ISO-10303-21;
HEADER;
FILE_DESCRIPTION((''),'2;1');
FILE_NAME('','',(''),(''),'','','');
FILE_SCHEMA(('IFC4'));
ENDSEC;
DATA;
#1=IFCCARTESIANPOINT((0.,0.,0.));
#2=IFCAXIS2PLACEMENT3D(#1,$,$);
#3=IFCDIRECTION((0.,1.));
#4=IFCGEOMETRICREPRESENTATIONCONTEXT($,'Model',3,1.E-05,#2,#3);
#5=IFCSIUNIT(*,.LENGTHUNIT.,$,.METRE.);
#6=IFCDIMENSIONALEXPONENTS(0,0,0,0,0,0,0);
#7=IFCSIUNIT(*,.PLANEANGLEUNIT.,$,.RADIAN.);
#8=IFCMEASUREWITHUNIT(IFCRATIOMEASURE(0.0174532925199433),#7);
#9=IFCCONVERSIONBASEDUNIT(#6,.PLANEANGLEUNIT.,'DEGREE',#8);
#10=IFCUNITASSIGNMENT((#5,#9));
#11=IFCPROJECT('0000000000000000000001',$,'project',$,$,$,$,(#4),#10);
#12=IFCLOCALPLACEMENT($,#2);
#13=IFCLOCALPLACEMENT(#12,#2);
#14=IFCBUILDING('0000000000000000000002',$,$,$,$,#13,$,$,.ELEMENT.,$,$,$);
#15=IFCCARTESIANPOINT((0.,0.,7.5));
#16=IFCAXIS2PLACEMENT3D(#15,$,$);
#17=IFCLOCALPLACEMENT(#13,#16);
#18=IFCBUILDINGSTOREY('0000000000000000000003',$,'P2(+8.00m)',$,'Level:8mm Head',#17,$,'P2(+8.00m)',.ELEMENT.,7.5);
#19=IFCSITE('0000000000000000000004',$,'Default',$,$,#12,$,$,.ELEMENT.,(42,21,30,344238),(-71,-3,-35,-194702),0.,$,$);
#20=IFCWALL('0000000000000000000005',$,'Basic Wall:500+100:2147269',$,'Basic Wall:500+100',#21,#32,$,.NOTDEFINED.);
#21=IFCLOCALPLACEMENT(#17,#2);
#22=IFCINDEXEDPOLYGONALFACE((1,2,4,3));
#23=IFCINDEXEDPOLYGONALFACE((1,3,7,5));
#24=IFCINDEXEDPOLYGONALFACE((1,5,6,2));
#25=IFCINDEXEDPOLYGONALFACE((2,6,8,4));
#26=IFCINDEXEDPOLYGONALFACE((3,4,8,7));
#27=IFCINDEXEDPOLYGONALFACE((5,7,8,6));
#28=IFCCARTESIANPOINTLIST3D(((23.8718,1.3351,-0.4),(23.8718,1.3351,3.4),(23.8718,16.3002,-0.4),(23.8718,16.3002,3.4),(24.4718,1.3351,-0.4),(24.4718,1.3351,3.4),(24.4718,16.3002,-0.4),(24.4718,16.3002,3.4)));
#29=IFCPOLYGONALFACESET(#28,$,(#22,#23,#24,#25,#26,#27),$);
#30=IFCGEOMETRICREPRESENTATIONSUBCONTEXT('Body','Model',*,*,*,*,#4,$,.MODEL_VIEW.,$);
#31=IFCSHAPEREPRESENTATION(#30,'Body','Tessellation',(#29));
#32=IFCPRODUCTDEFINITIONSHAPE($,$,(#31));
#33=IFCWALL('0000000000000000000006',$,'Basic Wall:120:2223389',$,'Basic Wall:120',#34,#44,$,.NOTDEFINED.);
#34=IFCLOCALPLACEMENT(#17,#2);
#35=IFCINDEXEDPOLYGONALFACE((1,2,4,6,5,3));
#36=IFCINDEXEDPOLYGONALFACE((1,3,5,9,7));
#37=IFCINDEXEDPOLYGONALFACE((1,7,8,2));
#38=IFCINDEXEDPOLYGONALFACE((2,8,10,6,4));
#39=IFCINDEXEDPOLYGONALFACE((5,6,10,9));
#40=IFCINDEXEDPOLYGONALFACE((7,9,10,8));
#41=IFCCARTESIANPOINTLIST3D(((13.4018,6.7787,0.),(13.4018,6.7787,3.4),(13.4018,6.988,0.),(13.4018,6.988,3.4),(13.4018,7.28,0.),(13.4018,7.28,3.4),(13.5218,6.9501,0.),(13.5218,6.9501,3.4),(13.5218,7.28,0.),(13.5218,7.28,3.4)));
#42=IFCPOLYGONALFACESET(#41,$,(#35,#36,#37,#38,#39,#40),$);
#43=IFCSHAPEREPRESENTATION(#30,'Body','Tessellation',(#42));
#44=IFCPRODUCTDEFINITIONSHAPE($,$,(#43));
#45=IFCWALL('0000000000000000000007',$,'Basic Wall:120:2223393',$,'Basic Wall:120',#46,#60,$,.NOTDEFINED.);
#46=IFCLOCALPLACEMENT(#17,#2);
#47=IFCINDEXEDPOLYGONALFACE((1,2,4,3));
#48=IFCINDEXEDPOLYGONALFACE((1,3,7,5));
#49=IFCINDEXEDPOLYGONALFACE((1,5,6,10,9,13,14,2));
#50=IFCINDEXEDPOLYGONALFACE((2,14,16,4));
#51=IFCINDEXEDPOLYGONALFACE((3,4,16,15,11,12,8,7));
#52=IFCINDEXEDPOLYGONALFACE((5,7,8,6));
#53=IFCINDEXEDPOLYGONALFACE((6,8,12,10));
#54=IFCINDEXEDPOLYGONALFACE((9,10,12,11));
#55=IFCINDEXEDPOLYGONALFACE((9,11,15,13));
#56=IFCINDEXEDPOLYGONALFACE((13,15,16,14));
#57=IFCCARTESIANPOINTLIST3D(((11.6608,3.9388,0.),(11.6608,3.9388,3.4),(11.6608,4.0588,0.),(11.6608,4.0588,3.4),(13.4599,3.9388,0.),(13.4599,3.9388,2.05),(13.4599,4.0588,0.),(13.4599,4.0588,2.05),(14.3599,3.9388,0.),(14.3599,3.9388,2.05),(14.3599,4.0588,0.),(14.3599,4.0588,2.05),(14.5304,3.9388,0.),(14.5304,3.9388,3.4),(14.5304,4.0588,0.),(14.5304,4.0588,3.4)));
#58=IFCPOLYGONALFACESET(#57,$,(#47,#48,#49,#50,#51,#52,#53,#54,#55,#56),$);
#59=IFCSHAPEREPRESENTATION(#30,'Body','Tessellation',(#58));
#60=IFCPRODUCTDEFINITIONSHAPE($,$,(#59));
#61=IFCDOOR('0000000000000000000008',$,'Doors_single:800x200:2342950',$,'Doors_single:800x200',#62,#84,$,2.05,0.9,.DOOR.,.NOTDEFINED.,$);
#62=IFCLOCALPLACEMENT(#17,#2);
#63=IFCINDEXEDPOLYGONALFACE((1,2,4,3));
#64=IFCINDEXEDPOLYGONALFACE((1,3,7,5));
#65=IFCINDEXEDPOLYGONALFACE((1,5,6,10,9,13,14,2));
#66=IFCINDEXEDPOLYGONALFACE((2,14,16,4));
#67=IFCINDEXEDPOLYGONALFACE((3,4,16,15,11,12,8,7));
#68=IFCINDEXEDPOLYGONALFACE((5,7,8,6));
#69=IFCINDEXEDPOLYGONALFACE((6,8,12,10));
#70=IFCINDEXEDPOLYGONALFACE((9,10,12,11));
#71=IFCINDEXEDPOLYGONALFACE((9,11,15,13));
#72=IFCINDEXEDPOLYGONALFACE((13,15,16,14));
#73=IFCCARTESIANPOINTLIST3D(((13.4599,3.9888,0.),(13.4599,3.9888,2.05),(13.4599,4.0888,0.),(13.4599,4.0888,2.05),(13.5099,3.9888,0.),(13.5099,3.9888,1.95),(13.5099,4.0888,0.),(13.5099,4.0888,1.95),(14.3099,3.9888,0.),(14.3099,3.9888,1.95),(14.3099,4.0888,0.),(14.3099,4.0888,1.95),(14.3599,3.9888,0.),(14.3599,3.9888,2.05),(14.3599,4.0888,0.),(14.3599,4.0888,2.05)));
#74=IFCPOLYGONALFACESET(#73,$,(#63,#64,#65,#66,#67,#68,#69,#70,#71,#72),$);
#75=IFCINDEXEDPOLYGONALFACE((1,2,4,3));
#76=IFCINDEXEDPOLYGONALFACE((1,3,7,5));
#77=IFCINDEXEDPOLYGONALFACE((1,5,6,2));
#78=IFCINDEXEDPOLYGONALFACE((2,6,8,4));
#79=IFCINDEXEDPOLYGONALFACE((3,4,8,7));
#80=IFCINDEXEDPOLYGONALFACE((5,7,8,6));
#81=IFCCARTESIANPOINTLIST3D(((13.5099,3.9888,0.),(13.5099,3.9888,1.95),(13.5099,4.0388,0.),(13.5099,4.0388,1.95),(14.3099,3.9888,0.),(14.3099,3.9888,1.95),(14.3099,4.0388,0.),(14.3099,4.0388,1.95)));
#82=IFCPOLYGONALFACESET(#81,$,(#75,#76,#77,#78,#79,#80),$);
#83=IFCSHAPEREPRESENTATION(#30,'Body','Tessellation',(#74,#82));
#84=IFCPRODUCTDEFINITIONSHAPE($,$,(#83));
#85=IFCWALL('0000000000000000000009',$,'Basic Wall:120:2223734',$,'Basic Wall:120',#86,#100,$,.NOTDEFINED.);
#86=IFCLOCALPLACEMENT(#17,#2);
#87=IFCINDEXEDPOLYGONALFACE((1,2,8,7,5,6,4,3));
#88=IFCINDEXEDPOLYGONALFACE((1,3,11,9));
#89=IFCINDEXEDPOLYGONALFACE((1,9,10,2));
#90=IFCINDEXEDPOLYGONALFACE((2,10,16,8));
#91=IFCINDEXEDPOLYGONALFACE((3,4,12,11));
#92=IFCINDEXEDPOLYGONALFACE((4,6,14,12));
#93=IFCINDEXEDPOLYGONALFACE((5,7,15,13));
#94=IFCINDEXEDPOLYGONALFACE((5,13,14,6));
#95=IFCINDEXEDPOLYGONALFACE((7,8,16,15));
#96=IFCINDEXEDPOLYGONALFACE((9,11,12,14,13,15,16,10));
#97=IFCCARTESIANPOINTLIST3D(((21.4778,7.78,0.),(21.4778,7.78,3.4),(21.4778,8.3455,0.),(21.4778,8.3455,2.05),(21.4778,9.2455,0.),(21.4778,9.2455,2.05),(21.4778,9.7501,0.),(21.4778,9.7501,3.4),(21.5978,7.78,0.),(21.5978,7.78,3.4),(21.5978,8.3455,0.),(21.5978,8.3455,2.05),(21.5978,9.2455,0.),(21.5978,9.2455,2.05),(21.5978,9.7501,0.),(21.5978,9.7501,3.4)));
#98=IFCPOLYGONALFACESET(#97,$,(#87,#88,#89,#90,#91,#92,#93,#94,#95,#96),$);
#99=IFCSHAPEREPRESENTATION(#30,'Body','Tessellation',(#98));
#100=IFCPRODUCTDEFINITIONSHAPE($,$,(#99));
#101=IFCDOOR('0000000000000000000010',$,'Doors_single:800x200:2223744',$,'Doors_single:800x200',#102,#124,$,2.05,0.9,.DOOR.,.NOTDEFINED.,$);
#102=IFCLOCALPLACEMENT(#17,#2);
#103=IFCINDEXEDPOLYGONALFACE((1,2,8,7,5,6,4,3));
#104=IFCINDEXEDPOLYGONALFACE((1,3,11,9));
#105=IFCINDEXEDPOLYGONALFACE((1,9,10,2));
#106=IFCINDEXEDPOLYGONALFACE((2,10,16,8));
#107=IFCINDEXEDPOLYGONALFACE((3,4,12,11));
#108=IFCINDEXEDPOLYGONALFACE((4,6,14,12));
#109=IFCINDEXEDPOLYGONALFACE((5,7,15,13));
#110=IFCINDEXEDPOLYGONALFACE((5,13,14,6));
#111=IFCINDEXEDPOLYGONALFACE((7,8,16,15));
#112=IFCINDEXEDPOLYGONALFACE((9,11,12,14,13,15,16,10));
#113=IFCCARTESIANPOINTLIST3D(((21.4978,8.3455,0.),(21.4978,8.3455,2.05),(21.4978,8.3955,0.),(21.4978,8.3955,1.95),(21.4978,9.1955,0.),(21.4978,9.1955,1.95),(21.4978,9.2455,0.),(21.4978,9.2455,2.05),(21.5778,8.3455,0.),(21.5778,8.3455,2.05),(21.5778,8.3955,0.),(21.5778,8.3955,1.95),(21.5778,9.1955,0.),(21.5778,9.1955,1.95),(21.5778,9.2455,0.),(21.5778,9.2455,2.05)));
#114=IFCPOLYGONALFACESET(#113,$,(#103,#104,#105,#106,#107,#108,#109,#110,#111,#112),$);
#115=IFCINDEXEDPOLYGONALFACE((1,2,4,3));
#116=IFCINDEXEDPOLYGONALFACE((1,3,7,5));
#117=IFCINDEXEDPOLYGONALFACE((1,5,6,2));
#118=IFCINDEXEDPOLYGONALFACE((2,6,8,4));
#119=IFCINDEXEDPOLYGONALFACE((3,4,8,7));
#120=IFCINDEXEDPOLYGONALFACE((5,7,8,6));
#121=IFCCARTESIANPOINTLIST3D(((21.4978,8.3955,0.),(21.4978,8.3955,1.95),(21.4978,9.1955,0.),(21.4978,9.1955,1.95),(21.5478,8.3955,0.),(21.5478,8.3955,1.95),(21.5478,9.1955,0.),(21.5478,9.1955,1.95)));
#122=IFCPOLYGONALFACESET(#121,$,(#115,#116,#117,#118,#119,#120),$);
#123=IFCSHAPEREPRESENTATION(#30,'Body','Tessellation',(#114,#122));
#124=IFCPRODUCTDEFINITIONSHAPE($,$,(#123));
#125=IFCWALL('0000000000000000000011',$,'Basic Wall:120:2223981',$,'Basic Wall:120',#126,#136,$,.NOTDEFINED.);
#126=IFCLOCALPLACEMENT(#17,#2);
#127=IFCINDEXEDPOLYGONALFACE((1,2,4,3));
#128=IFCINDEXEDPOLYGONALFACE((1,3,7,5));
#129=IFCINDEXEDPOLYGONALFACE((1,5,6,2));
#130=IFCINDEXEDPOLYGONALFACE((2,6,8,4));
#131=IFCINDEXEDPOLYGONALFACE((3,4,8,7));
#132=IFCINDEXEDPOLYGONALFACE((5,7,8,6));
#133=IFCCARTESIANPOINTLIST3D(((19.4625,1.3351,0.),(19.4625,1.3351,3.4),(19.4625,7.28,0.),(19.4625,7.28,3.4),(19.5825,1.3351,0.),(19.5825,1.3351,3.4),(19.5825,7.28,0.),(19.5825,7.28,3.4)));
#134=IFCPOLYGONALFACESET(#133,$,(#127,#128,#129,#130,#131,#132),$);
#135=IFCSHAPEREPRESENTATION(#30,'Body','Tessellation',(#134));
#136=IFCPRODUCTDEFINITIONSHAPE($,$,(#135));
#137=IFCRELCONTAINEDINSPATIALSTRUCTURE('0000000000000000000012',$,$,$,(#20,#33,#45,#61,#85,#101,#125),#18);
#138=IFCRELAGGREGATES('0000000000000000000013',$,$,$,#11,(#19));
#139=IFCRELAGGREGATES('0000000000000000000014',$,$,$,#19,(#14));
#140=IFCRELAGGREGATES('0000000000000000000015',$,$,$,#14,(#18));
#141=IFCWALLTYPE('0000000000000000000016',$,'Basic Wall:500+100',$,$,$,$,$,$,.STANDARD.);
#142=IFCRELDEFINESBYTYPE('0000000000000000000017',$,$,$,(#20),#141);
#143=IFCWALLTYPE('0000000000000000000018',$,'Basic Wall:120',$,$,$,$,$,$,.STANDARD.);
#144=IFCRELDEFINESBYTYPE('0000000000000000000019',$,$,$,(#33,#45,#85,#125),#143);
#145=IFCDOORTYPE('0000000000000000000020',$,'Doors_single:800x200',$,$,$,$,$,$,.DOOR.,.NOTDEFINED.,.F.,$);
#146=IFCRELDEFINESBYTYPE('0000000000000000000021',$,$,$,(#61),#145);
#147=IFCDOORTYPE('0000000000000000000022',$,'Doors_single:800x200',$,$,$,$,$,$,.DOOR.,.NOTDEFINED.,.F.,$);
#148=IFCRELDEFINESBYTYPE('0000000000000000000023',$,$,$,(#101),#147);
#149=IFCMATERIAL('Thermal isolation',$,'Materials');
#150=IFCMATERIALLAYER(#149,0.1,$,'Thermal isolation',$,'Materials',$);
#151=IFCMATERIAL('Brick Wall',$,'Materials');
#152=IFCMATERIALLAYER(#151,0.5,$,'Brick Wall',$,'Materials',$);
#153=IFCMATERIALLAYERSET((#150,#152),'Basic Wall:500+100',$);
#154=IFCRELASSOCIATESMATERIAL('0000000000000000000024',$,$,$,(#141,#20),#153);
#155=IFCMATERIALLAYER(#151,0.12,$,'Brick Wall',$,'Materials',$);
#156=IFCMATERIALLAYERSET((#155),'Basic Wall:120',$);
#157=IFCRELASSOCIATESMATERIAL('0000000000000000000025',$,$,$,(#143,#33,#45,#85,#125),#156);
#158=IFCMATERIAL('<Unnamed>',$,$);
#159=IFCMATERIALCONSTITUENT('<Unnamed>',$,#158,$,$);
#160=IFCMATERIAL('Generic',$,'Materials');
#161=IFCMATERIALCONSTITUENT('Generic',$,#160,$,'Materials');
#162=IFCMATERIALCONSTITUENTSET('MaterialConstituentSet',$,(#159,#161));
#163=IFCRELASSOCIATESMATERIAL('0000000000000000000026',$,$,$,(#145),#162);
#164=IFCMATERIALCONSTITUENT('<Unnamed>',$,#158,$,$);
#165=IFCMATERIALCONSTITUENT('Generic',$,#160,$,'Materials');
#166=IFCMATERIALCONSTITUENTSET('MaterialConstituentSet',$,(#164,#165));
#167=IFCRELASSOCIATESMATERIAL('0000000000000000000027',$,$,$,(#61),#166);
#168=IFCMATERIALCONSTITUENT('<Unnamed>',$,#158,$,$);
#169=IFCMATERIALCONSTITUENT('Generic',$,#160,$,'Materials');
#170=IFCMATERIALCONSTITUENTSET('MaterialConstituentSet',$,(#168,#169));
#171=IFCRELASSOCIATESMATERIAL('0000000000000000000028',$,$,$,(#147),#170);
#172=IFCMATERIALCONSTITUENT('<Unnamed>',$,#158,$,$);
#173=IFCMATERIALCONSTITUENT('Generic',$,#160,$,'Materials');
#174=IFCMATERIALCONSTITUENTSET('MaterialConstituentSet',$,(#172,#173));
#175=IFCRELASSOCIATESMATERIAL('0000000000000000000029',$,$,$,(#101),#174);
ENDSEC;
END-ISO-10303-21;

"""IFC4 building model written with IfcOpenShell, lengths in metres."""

from ifc_helpers import new_model, entity, si_unit, converted_unit, direction, frame, frame_2d, origin, origin_2d_with_axis, place, context, subcontext, project, spatial, polyline, rectangle, outline, extrude, source, transform, mapped, material, layer, layer_set, layer_usage, constituent, constituent_set, type_object, type_shapes, element, fill, save


model = new_model("IFC4")

# Units and contexts
model_context = context("Model", 3, precision=1e-05, world=origin(), true_north=direction((0.0, 1.0)))
body_context = subcontext(model_context, "Body", "Model", "MODEL_VIEW")
ifc_project = project(units=[si_unit("LENGTHUNIT", "METRE"), converted_unit("PLANEANGLEUNIT", "DEGREE", entity("IfcRatioMeasure", 0.0174532925199433), si_unit("PLANEANGLEUNIT", "RADIAN"), dimensions=[0, 0, 0, 0, 0, 0, 0])], contexts=[model_context])

# Site, building, storey
site_placement = place(None, origin())
site = spatial("IfcSite", under=ifc_project, at=site_placement, Name="Default", CompositionType="ELEMENT", RefLatitude=(42, 21, 30, 344238), RefLongitude=(-71, -3, -35, -194702), RefElevation=0.0)
building_placement = place(site_placement, origin())
building = spatial("IfcBuilding", under=site, at=building_placement, CompositionType="ELEMENT")
storey_placement = place(building_placement, frame((0.0, 0.0, 7.5)))
storey = spatial("IfcBuildingStorey", under=building, at=storey_placement, Name="P2(+8.00m)", ObjectType="Level:8mm Head", LongName="P2(+8.00m)", CompositionType="ELEMENT", Elevation=7.5)

# Shared definitions
ifc_material_1 = material(Name="Thermal isolation", Category="Materials")
ifc_layer_1 = layer(ifc_material_1, 0.1, Name="Thermal isolation", Category="Materials")
ifc_material_2 = material(Name="Brick Wall", Category="Materials")
ifc_layer_2 = layer(ifc_material_2, 0.5, Name="Brick Wall", Category="Materials")
ifc_layer_set_1 = layer_set([ifc_layer_1, ifc_layer_2], Name="Basic Wall:500+100")
wall_type_1 = type_object("IfcWallType", Name="Basic Wall:500+100", PredefinedType="STANDARD", material=ifc_layer_set_1)
ifc_material_3 = material(Name="<Unnamed>")
ifc_material_4 = material(Name="Generic", Category="Materials")

# Walls
ifc_layer_usage_1 = layer_usage(ifc_layer_set_1, "AXIS2", "POSITIVE", -0.3)
wall_1_placement = place(storey_placement, frame((24.1718, 1.3351, -0.4), z_axis=(0.0, 0.0, 1.0), x_axis=(0.0, 1.0, 0.0)))
element("IfcWall", 1, at=wall_1_placement, inside=storey, type_object=wall_type_1, material=ifc_layer_usage_1, Name="Basic Wall:500+100:2147269", ObjectType="Basic Wall:500+100", PredefinedType="NOTDEFINED", context=body_context, shape_type="SweptSolid", body=[
    extrude(rectangle(XDim=14.9651, YDim=0.6, at=frame_2d((7.4826, 0.0), x_axis=(-1.0, 0.0))), origin(), (0.0, 0.0, 1.0), 3.8),
])
ifc_layer_3 = layer(ifc_material_2, 0.12, Name="Brick Wall", Category="Materials")
ifc_layer_set_2 = layer_set([ifc_layer_3], Name="Basic Wall:120")
ifc_layer_usage_2 = layer_usage(ifc_layer_set_2, "AXIS2", "POSITIVE", -0.06)
wall_type_2 = type_object("IfcWallType", Name="Basic Wall:120", PredefinedType="STANDARD", material=ifc_layer_set_2)
wall_2_placement = place(storey_placement, frame((13.4618, 7.28, 0.0), z_axis=(0.0, 0.0, 1.0), x_axis=(0.0, -1.0, 0.0)))
element("IfcWall", 2, at=wall_2_placement, inside=storey, type_object=wall_type_2, material=ifc_layer_usage_2, Name="Basic Wall:120:2223389", ObjectType="Basic Wall:120", PredefinedType="NOTDEFINED", context=body_context, shape_type="SweptSolid", body=[
    extrude(outline(polyline([(0.5012, -0.06), (0.3298, 0.06), (0.0, 0.06), (0.0, -0.06), (0.292, -0.06), (0.5012, -0.06)])), origin(), (0.0, 0.0, 1.0), 3.4),
])

# Walls, openings, doors
ifc_layer_usage_3 = layer_usage(ifc_layer_set_2, "AXIS2", "POSITIVE", -0.06)
wall_3_placement = place(storey_placement, frame((14.5304, 3.9988, 0.0), z_axis=(0.0, 0.0, 1.0), x_axis=(-1.0, 0.0, 0.0)))
wall_3 = element("IfcWall", 3, at=wall_3_placement, inside=storey, type_object=wall_type_2, material=ifc_layer_usage_3, Name="Basic Wall:120:2223393", ObjectType="Basic Wall:120", PredefinedType="NOTDEFINED", context=body_context, shape_type="SweptSolid", body=[
    extrude(rectangle(XDim=2.8696, YDim=0.12, at=frame_2d((1.4348, 0.0), x_axis=(-1.0, 0.0))), origin(), (0.0, 0.0, 1.0), 3.4),
])
opening_1_placement = place(wall_3_placement, frame((0.1705, -0.06, 0.0)))
opening_1 = element("IfcOpeningElement", 4, at=opening_1_placement, cuts=wall_3, PredefinedType="OPENING", context=body_context, shape_type="SweptSolid", body=[
    extrude(rectangle(XDim=2.05, YDim=0.9, at=frame_2d((1.025, 0.45), x_axis=(1.0, 0.0))), frame((0.0, 0.0, 0.0), z_axis=(0.0, 1.0, 0.0), x_axis=(0.0, 0.0, 1.0)), (0.0, 0.0, 1.0), 0.12),
])
ifc_constituent_1 = constituent(ifc_material_3, Name="<Unnamed>")
ifc_constituent_2 = constituent(ifc_material_4, Name="Generic", Category="Materials")
ifc_constituent_set_1 = constituent_set(constituents=[ifc_constituent_1, ifc_constituent_2], Name="MaterialConstituentSet")
ifc_constituent_3 = constituent(ifc_material_3, Name="<Unnamed>")
ifc_constituent_4 = constituent(ifc_material_4, Name="Generic", Category="Materials")
ifc_constituent_set_2 = constituent_set(constituents=[ifc_constituent_3, ifc_constituent_4], Name="MaterialConstituentSet")
door_type_1 = type_object("IfcDoorType", Name="Doors_single:800x200", OperationType="NOTDEFINED", ParameterTakesPrecedence=False, PredefinedType="DOOR", material=ifc_constituent_set_2)
shared_shape_1 = source(origin(), body_context, "Body", "SweptSolid", [
    extrude(outline(polyline([(-0.45, -1.0), (-0.4, -1.0), (-0.4, 0.95), (0.4, 0.95), (0.4, -1.0), (0.45, -1.0), (0.45, 1.05), (-0.45, 1.05), (-0.45, -1.0)])), frame((0.45, -0.03, 1.0), z_axis=(0.0, 1.0, 0.0), x_axis=(-1.0, 0.0, 0.0)), (0.0, 0.0, 1.0), 0.1),
    extrude(rectangle(XDim=0.8, YDim=0.05, at=origin_2d_with_axis()), frame((0.45, 0.045, 0.0), z_axis=(0.0, 0.0, 1.0), x_axis=(-1.0, 0.0, 0.0)), (0.0, 0.0, 1.0), 1.95),
])
type_shapes(door_type_1, [shared_shape_1])
door_1_placement = place(opening_1_placement, origin())
door_1 = element("IfcDoor", 5, at=door_1_placement, inside=storey, type_object=door_type_1, material=ifc_constituent_set_1, Name="Doors_single:800x200:2342950", ObjectType="Doors_single:800x200", OperationType="NOTDEFINED", OverallHeight=2.05, OverallWidth=0.9, PredefinedType="DOOR", context=body_context, shape_type="MappedRepresentation", body=[
    mapped(shared_shape_1, transform((0.0, 0.0, 0.0), scale=1.0)),
])
fill(opening_1, door_1)
ifc_layer_usage_4 = layer_usage(ifc_layer_set_2, "AXIS2", "NEGATIVE", 0.06)
wall_4_placement = place(storey_placement, frame((21.5378, 9.7501, 0.0), z_axis=(0.0, 0.0, 1.0), x_axis=(0.0, -1.0, 0.0)))
wall_4 = element("IfcWall", 6, at=wall_4_placement, inside=storey, type_object=wall_type_2, material=ifc_layer_usage_4, Name="Basic Wall:120:2223734", ObjectType="Basic Wall:120", PredefinedType="NOTDEFINED", context=body_context, shape_type="SweptSolid", body=[
    extrude(rectangle(XDim=1.9701, YDim=0.12, at=frame_2d((0.985, 0.0), x_axis=(-1.0, 0.0))), origin(), (0.0, 0.0, 1.0), 3.4),
])
opening_2_placement = place(wall_4_placement, frame((1.4045, 0.06, 0.0)))
opening_2 = element("IfcOpeningElement", 7, at=opening_2_placement, cuts=wall_4, PredefinedType="OPENING", context=body_context, shape_type="SweptSolid", body=[
    extrude(rectangle(XDim=2.05, YDim=0.9, at=frame_2d((1.025, 0.45), x_axis=(1.0, 0.0))), frame((0.0, 0.0, 0.0), z_axis=(0.0, -1.0, 0.0), x_axis=(0.0, 0.0, 1.0)), (0.0, 0.0, 1.0), 0.12),
])
ifc_constituent_5 = constituent(ifc_material_3, Name="<Unnamed>")
ifc_constituent_6 = constituent(ifc_material_4, Name="Generic", Category="Materials")
ifc_constituent_set_3 = constituent_set(constituents=[ifc_constituent_5, ifc_constituent_6], Name="MaterialConstituentSet")
ifc_constituent_7 = constituent(ifc_material_3, Name="<Unnamed>")
ifc_constituent_8 = constituent(ifc_material_4, Name="Generic", Category="Materials")
ifc_constituent_set_4 = constituent_set(constituents=[ifc_constituent_7, ifc_constituent_8], Name="MaterialConstituentSet")
door_type_2 = type_object("IfcDoorType", Name="Doors_single:800x200", OperationType="NOTDEFINED", ParameterTakesPrecedence=False, PredefinedType="DOOR", material=ifc_constituent_set_4)
shared_shape_2 = source(origin(), body_context, "Body", "SweptSolid", [
    extrude(outline(polyline([(-0.45, -1.0), (-0.4, -1.0), (-0.4, 0.95), (0.4, 0.95), (0.4, -1.0), (0.45, -1.0), (0.45, 1.05), (-0.45, 1.05), (-0.45, -1.0)])), frame((0.45, 0.02, 1.0), z_axis=(0.0, 1.0, 0.0), x_axis=(-1.0, 0.0, 0.0)), (0.0, 0.0, 1.0), 0.08),
    extrude(rectangle(XDim=0.8, YDim=0.05, at=origin_2d_with_axis()), frame((0.45, 0.075, 0.0), z_axis=(0.0, 0.0, 1.0), x_axis=(-1.0, 0.0, 0.0)), (0.0, 0.0, 1.0), 1.95),
])
type_shapes(door_type_2, [shared_shape_2])
door_2_placement = place(opening_2_placement, frame((0.0, 0.0, 0.0), z_axis=(0.0, 0.0, 1.0), x_axis=(-1.0, 0.0, 0.0)))
door_2 = element("IfcDoor", 8, at=door_2_placement, inside=storey, type_object=door_type_2, material=ifc_constituent_set_3, Name="Doors_single:800x200:2223744", ObjectType="Doors_single:800x200", OperationType="NOTDEFINED", OverallHeight=2.05, OverallWidth=0.9, PredefinedType="DOOR", context=body_context, shape_type="MappedRepresentation", body=[
    mapped(shared_shape_2, transform((0.0, 0.0, 0.0), scale=1.0)),
])
fill(opening_2, door_2)

# Wall
ifc_layer_usage_5 = layer_usage(ifc_layer_set_2, "AXIS2", "POSITIVE", -0.06)
wall_5_placement = place(storey_placement, frame((19.5225, 7.28, 0.0), z_axis=(0.0, 0.0, 1.0), x_axis=(0.0, -1.0, 0.0)))
element("IfcWall", 9, at=wall_5_placement, inside=storey, type_object=wall_type_2, material=ifc_layer_usage_5, Name="Basic Wall:120:2223981", ObjectType="Basic Wall:120", PredefinedType="NOTDEFINED", context=body_context, shape_type="SweptSolid", body=[
    extrude(rectangle(XDim=5.9449, YDim=0.12, at=frame_2d((2.9724, 0.0), x_axis=(-1.0, 0.0))), origin(), (0.0, 0.0, 1.0), 3.4),
])

save(model, "model.ifc")
